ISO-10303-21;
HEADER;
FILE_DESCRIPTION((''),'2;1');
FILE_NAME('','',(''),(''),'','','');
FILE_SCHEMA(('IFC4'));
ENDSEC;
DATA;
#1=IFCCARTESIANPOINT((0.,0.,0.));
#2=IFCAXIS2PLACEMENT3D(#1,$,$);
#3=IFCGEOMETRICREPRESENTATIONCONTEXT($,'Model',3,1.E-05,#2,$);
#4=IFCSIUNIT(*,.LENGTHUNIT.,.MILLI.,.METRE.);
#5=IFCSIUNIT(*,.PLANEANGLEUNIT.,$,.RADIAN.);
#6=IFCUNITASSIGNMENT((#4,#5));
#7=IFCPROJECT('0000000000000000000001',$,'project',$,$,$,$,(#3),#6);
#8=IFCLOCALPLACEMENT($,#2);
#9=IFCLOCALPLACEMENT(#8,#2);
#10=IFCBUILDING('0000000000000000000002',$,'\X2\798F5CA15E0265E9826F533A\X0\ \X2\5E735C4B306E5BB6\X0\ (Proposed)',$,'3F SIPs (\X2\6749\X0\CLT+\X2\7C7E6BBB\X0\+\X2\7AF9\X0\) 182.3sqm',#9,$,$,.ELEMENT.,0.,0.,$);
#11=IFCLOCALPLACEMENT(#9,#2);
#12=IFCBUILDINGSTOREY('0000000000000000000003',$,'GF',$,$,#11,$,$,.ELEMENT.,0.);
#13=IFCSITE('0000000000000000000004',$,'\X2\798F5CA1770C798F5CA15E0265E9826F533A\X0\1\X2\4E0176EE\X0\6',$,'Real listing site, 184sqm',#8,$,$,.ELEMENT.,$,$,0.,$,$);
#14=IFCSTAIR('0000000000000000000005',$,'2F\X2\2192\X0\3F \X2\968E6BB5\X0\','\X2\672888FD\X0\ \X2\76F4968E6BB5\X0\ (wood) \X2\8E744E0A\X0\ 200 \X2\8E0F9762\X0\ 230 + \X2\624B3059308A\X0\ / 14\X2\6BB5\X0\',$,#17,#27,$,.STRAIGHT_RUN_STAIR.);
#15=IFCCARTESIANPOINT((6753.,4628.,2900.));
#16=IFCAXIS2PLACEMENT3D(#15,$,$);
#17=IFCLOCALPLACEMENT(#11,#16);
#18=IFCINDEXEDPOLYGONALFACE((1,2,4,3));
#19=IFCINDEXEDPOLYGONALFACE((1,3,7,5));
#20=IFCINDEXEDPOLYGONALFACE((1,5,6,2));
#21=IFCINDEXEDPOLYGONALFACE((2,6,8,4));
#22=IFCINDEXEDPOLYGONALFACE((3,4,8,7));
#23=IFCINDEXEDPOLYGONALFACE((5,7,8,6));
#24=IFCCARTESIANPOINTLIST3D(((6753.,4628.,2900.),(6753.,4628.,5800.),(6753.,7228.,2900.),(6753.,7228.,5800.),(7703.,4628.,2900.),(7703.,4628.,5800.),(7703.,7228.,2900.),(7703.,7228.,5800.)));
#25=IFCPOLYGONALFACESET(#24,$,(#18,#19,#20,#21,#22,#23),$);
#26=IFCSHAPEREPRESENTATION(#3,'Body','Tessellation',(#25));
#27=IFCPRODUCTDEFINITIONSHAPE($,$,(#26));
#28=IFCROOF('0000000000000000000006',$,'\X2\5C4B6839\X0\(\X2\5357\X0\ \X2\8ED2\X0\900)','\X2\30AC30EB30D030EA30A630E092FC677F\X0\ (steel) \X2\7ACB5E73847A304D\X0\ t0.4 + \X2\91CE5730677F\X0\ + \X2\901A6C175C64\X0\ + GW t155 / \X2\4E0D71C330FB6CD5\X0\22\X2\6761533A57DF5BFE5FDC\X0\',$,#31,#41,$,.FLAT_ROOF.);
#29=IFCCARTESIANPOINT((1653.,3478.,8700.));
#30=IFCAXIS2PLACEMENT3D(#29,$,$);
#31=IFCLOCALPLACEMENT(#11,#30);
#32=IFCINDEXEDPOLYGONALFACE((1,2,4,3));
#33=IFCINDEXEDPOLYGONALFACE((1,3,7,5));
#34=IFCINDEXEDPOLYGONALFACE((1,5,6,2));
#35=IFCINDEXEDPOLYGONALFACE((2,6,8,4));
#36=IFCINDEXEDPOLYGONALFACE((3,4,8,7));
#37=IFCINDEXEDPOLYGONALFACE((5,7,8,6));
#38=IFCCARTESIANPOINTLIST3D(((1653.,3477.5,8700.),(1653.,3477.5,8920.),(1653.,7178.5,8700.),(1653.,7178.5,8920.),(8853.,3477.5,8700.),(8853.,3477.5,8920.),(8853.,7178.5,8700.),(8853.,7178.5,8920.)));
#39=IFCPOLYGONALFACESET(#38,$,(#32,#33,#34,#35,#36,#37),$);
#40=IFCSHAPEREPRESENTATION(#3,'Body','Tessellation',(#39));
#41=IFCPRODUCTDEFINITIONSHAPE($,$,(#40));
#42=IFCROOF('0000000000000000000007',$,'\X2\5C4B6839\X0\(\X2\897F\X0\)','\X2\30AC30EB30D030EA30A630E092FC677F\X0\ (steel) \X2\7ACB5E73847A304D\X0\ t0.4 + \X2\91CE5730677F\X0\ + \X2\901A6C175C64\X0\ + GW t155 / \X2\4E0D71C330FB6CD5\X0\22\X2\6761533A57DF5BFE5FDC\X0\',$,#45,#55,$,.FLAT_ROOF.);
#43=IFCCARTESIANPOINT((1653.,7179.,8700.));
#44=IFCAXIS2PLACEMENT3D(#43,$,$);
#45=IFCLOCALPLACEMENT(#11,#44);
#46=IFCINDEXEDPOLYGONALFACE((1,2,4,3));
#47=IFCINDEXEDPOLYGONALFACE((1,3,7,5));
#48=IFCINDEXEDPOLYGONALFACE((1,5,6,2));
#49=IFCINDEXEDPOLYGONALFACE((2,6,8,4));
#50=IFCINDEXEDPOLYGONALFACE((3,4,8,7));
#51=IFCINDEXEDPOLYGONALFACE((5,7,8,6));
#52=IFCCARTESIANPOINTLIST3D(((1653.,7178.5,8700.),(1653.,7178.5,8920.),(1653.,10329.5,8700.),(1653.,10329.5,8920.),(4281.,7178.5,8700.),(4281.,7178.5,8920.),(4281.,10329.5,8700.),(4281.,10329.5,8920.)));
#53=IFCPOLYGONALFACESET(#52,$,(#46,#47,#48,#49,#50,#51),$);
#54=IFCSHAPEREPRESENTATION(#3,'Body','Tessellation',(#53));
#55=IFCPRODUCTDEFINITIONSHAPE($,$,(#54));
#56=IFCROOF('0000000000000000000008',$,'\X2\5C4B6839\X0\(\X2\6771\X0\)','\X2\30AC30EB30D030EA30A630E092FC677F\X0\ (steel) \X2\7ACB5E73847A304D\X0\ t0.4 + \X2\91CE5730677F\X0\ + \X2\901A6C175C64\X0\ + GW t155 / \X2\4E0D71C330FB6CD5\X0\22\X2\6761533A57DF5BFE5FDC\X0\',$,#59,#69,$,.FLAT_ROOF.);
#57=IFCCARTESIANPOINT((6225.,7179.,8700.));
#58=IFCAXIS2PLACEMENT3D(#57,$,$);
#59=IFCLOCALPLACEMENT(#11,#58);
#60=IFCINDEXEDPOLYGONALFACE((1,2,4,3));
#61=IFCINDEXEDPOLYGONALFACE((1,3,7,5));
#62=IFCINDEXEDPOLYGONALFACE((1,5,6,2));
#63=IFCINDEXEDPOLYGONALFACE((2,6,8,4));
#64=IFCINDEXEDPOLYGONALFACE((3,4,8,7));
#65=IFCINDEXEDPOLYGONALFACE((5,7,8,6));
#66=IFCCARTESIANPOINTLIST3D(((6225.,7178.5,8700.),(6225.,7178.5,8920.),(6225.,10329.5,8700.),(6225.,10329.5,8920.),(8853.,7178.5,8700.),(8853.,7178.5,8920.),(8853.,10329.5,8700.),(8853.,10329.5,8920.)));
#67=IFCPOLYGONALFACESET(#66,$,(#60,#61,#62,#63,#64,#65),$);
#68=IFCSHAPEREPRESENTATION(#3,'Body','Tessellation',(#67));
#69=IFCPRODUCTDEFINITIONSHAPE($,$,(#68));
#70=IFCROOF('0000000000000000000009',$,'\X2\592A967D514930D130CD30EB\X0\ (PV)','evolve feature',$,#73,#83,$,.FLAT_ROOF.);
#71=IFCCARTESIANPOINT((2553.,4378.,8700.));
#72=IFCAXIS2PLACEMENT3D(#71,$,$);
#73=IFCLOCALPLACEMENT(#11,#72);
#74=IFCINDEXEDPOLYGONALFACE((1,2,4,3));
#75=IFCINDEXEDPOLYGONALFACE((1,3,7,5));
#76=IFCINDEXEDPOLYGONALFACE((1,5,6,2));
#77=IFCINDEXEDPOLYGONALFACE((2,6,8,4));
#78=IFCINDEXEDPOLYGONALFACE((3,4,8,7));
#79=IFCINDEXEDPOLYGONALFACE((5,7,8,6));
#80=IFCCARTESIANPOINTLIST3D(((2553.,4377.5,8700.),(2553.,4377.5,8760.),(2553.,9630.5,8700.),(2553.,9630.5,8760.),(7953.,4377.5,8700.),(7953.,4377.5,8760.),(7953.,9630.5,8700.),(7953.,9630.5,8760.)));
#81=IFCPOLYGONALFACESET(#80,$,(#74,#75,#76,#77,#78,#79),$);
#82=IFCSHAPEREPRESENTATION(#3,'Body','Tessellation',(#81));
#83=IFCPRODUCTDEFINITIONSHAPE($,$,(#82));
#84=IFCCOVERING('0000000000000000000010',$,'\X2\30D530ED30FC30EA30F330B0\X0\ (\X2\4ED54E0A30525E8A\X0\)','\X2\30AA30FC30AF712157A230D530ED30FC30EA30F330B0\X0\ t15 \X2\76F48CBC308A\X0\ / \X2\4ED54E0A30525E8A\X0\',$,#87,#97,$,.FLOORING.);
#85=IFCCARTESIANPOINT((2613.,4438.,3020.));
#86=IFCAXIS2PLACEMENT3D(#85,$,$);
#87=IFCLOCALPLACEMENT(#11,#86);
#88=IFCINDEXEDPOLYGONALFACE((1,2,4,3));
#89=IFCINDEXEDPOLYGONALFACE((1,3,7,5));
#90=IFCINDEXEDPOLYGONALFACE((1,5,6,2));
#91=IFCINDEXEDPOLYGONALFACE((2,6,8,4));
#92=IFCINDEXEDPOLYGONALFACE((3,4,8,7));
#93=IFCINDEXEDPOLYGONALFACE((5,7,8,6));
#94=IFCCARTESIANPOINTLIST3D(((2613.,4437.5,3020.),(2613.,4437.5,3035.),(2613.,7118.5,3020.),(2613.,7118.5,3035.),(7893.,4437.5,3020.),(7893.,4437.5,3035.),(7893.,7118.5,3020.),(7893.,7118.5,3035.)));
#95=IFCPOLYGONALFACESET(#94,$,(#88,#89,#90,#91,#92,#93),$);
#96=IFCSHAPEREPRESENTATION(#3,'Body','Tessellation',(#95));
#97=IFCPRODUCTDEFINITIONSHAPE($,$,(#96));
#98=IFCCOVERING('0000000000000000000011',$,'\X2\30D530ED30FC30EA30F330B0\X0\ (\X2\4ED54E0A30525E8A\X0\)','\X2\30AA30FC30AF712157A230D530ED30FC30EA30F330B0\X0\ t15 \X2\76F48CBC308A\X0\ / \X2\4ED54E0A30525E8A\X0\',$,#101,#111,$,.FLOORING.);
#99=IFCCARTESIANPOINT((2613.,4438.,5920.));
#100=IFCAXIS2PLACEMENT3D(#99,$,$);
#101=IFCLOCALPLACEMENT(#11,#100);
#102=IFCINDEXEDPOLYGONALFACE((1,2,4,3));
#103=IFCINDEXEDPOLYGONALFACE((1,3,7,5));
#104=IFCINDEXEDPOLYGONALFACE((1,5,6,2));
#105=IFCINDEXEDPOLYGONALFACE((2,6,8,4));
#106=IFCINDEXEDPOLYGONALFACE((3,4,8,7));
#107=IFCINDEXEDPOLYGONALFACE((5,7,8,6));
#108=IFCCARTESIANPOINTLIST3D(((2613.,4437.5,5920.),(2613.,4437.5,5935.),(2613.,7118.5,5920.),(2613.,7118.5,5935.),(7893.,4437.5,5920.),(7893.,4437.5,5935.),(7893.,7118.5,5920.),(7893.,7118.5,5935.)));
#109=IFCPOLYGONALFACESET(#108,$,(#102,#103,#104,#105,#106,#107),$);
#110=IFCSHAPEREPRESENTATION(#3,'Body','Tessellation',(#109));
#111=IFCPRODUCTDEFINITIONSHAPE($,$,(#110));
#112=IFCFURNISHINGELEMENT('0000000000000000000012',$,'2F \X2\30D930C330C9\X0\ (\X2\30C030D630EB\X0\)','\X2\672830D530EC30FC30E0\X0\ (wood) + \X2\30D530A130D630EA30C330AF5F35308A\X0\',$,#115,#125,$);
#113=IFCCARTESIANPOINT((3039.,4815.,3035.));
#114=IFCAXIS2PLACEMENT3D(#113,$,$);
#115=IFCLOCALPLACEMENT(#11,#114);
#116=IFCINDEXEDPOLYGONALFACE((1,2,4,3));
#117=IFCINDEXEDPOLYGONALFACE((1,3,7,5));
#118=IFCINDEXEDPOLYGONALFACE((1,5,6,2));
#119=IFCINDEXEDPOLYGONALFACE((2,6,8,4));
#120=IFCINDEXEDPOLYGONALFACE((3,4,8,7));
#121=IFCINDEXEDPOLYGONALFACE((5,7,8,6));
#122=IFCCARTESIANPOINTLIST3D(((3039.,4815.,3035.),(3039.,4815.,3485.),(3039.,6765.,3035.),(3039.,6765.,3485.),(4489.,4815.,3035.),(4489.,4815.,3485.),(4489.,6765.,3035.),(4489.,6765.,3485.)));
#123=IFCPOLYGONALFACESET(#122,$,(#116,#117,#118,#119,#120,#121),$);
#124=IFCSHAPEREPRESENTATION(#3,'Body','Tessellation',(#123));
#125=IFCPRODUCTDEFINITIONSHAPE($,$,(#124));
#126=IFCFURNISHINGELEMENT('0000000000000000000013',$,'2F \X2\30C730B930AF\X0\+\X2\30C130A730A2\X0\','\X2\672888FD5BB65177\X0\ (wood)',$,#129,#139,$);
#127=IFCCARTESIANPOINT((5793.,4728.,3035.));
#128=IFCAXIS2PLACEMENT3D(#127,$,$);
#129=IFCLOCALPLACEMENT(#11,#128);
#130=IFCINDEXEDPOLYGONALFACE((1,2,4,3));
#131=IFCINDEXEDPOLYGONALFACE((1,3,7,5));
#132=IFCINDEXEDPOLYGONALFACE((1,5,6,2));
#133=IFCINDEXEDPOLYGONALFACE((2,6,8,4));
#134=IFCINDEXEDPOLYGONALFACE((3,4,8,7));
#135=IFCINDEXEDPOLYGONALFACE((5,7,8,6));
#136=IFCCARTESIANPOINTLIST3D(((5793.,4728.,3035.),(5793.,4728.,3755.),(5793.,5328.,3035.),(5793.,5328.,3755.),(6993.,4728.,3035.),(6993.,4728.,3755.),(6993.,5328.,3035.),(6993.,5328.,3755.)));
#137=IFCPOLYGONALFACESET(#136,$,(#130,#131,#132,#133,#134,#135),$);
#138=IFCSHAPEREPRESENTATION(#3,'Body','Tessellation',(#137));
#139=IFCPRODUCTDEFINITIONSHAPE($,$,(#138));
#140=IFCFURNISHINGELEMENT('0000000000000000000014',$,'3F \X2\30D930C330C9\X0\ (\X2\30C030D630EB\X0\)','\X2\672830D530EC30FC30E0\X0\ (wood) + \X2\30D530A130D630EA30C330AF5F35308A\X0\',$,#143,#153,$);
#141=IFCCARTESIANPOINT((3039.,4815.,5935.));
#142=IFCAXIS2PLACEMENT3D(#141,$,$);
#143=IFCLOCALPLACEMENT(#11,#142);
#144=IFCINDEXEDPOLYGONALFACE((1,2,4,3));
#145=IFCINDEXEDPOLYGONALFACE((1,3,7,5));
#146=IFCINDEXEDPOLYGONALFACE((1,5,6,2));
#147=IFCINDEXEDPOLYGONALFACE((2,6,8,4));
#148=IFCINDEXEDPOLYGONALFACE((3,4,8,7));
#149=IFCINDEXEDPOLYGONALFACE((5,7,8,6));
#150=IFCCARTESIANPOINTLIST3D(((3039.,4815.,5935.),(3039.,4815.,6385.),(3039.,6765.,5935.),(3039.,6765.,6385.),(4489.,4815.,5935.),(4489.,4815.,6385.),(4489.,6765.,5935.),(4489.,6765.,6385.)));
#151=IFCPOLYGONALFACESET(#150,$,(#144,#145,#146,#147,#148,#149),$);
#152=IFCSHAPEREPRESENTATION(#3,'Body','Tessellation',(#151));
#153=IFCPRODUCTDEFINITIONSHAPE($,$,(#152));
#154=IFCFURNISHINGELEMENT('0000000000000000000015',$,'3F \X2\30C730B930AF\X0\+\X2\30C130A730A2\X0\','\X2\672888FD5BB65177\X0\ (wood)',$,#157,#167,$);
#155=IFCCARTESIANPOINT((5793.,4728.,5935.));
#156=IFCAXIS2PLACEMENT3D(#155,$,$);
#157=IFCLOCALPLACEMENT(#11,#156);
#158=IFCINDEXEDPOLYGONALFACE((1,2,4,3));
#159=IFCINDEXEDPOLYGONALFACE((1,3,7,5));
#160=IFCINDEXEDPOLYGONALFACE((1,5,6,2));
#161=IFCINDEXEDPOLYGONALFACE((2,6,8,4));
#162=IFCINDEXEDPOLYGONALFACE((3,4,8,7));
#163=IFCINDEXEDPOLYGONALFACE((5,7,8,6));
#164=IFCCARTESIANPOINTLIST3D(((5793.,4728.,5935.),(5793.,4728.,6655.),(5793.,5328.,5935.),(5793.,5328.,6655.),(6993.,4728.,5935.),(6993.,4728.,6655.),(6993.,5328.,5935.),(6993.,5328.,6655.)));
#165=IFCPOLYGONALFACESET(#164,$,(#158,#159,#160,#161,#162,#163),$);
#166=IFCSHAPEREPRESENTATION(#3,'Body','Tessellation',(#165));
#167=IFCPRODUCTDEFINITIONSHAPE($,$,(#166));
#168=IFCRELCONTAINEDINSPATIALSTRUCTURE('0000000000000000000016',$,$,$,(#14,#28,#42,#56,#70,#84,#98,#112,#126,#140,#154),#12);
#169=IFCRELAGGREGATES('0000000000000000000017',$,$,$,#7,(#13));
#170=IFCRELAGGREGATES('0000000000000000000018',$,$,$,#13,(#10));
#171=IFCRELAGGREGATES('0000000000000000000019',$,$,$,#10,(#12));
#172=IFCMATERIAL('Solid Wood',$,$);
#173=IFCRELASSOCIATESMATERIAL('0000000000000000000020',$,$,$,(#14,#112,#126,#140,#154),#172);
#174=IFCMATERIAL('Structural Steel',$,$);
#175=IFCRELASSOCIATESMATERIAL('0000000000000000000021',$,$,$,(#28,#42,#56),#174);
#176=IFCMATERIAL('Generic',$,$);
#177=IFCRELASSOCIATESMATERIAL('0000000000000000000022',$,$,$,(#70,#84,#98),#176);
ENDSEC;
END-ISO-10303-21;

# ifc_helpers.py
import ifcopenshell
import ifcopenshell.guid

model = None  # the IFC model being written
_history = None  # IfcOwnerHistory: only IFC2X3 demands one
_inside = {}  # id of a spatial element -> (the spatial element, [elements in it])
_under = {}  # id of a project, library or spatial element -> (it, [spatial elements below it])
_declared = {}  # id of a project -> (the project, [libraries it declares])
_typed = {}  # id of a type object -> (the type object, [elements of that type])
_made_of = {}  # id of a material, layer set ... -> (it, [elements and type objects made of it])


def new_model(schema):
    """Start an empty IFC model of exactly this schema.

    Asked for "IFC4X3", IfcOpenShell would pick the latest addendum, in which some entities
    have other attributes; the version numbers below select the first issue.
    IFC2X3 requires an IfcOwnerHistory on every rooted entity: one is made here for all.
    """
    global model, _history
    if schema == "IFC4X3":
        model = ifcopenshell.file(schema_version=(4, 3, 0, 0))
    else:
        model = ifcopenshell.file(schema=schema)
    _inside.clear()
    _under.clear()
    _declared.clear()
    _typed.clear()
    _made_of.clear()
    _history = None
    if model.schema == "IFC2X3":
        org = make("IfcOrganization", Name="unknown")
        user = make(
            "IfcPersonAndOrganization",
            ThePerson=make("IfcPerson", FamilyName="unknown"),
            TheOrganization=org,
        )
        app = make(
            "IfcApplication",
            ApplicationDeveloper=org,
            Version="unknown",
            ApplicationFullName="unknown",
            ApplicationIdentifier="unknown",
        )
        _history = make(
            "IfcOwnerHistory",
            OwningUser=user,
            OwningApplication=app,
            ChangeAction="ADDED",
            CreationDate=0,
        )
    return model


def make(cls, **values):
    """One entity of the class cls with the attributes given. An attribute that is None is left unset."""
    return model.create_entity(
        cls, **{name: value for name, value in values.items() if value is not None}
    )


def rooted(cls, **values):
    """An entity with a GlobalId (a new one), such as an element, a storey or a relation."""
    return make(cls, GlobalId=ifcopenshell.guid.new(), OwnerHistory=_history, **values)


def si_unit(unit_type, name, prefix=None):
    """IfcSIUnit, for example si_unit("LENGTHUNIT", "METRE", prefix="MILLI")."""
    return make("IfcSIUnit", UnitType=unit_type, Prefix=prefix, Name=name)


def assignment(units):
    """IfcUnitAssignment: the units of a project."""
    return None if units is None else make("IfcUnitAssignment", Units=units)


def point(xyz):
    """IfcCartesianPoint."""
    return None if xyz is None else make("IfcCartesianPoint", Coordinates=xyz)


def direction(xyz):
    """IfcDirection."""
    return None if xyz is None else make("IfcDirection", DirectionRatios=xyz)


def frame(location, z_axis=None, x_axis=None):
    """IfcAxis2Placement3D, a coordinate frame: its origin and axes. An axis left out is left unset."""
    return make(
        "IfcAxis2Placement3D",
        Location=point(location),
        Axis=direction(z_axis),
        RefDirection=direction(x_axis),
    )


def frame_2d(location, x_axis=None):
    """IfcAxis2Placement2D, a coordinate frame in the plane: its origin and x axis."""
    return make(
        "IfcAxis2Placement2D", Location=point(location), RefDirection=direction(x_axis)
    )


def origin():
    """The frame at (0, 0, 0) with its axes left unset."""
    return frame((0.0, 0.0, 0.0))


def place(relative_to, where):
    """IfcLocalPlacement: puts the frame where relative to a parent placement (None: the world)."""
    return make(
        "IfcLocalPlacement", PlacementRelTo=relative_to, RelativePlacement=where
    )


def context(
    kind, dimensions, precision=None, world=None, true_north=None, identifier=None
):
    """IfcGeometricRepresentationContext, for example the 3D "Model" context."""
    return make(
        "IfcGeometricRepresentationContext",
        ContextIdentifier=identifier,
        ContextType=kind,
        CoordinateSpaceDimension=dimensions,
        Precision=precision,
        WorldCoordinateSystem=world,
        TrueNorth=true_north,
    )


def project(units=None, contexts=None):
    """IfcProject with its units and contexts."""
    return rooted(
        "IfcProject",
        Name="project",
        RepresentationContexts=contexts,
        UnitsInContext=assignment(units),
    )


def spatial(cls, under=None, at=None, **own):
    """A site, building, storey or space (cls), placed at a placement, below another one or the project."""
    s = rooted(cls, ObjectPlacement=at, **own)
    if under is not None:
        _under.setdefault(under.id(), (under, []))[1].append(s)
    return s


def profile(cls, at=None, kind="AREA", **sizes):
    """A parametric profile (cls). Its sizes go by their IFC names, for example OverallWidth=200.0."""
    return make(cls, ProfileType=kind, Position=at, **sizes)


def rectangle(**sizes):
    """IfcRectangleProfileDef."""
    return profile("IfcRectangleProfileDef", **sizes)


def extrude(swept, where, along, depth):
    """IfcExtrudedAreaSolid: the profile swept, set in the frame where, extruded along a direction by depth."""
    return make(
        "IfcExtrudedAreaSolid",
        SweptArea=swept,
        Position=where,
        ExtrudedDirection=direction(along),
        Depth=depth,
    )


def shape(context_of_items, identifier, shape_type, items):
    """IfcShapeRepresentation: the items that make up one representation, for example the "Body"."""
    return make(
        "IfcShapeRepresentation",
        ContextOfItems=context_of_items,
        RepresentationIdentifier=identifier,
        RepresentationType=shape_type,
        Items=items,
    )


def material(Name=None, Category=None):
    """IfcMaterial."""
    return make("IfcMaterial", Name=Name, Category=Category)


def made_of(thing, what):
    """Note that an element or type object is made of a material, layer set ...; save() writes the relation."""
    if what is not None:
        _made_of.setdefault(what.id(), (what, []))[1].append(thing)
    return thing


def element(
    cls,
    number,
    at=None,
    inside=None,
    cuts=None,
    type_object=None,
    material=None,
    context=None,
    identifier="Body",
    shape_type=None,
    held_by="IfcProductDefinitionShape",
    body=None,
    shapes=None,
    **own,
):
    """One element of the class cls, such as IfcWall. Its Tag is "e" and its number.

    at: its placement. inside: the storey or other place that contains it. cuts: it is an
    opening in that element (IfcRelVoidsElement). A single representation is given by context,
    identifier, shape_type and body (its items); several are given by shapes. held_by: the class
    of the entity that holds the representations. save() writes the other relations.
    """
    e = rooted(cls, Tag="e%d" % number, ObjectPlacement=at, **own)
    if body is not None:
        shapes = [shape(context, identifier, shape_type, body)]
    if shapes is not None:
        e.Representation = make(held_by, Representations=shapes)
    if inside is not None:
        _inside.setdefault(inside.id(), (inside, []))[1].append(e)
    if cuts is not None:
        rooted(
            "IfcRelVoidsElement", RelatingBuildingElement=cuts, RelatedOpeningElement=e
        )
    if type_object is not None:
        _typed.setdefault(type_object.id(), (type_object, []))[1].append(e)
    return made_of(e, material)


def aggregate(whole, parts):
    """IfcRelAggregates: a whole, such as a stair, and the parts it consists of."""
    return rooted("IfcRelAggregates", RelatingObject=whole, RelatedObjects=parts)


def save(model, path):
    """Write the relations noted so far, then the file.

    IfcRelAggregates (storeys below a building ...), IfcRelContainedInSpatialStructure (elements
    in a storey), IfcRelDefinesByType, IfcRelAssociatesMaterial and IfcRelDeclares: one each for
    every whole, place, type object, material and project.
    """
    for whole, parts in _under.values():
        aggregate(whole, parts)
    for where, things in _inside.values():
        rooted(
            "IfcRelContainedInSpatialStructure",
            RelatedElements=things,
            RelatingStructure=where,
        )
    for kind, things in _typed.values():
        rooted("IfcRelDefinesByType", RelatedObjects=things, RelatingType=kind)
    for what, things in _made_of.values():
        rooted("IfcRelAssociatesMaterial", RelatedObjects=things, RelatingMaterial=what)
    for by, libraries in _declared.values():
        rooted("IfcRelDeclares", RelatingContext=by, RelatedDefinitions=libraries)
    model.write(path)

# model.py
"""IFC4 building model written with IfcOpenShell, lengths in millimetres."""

from ifc_helpers import new_model, si_unit, frame, frame_2d, origin, place, context, project, spatial, rectangle, extrude, material, element, save


model = new_model("IFC4")

# Units and contexts
model_context = context("Model", 3, precision=1e-05, world=origin())
ifc_project = project(units=[si_unit("LENGTHUNIT", "METRE", prefix="MILLI"), si_unit("PLANEANGLEUNIT", "RADIAN")], contexts=[model_context])

# Site, building, storey
site_placement = place(None, origin())
site = spatial("IfcSite", under=ifc_project, at=site_placement, Name="福岡県福岡市早良区1丁目6", ObjectType="Real listing site, 184sqm", CompositionType="ELEMENT", RefElevation=0.0)
building_placement = place(site_placement, origin())
building = spatial("IfcBuilding", under=site, at=building_placement, Name="福岡市早良区 平屋の家 (Proposed)", ObjectType="3F SIPs (杉CLT+籾殻+竹) 182.3sqm", CompositionType="ELEMENT", ElevationOfRefHeight=0.0, ElevationOfTerrain=0.0)
storey_placement = place(building_placement, origin())
storey = spatial("IfcBuildingStorey", under=building, at=storey_placement, Name="GF", CompositionType="ELEMENT", Elevation=0.0)

# Shared definitions
ifc_material_1 = material(Name="Solid Wood")

# Stair
stair_placement = place(storey_placement, frame((6753.0, 4628.0, 2900.0)))
element("IfcStair", 1, at=stair_placement, inside=storey, material=ifc_material_1, Name="2F→3F 階段", Description="木製 直階段 (wood) 蹴上 200 踏面 230 + 手すり / 14段", PredefinedType="STRAIGHT_RUN_STAIR", context=model_context, shape_type="SweptSolid", body=[
    extrude(rectangle(XDim=950.0, YDim=2600.0, at=frame_2d((475.0, 1300.0))), frame((6753.0, 4628.0, 2900.0)), (0.0, 0.0, 1.0), 2900.0),
])

# Roofs
ifc_material_2 = material(Name="Structural Steel")
roof_1_placement = place(storey_placement, frame((1653.0, 3478.0, 8700.0)))
element("IfcRoof", 2, at=roof_1_placement, inside=storey, material=ifc_material_2, Name="屋根(南 軒900)", Description="ガルバリウム鋼板 (steel) 立平葺き t0.4 + 野地板 + 通気層 + GW t155 / 不燃・法22条区域対応", PredefinedType="FLAT_ROOF", context=model_context, shape_type="SweptSolid", body=[
    extrude(rectangle(XDim=7200.0, YDim=3701.0, at=frame_2d((3600.0, 1850.0))), frame((1653.0, 3478.0, 8700.0)), (0.0, 0.0, 1.0), 220.0),
])
roof_2_placement = place(storey_placement, frame((1653.0, 7179.0, 8700.0)))
element("IfcRoof", 3, at=roof_2_placement, inside=storey, material=ifc_material_2, Name="屋根(西)", Description="ガルバリウム鋼板 (steel) 立平葺き t0.4 + 野地板 + 通気層 + GW t155 / 不燃・法22条区域対応", PredefinedType="FLAT_ROOF", context=model_context, shape_type="SweptSolid", body=[
    extrude(rectangle(XDim=2628.0, YDim=3151.0, at=frame_2d((1314.0, 1575.0))), frame((1653.0, 7179.0, 8700.0)), (0.0, 0.0, 1.0), 220.0),
])
roof_3_placement = place(storey_placement, frame((6225.0, 7179.0, 8700.0)))
element("IfcRoof", 4, at=roof_3_placement, inside=storey, material=ifc_material_2, Name="屋根(東)", Description="ガルバリウム鋼板 (steel) 立平葺き t0.4 + 野地板 + 通気層 + GW t155 / 不燃・法22条区域対応", PredefinedType="FLAT_ROOF", context=model_context, shape_type="SweptSolid", body=[
    extrude(rectangle(XDim=2628.0, YDim=3151.0, at=frame_2d((1314.0, 1575.0))), frame((6225.0, 7179.0, 8700.0)), (0.0, 0.0, 1.0), 220.0),
])
ifc_material_3 = material(Name="Generic")
roof_4_placement = place(storey_placement, frame((2553.0, 4378.0, 8700.0)))
element("IfcRoof", 5, at=roof_4_placement, inside=storey, material=ifc_material_3, Name="太陽光パネル (PV)", Description="evolve feature", PredefinedType="FLAT_ROOF", context=model_context, shape_type="SweptSolid", body=[
    extrude(rectangle(XDim=5400.0, YDim=5253.0, at=frame_2d((2700.0, 2626.0))), frame((2553.0, 4378.0, 8700.0)), (0.0, 0.0, 1.0), 60.0),
])

# Coverings
covering_1_placement = place(storey_placement, frame((2613.0, 4438.0, 3020.0)))
element("IfcCovering", 6, at=covering_1_placement, inside=storey, material=ifc_material_3, Name="フローリング (仕上げ床)", Description="オーク無垢フローリング t15 直貼り / 仕上げ床", PredefinedType="FLOORING", context=model_context, shape_type="SweptSolid", body=[
    extrude(rectangle(XDim=5280.0, YDim=2681.0, at=frame_2d((2640.0, 1340.0))), frame((2613.0, 4438.0, 3020.0)), (0.0, 0.0, 1.0), 15.0),
])
covering_2_placement = place(storey_placement, frame((2613.0, 4438.0, 5920.0)))
element("IfcCovering", 7, at=covering_2_placement, inside=storey, material=ifc_material_3, Name="フローリング (仕上げ床)", Description="オーク無垢フローリング t15 直貼り / 仕上げ床", PredefinedType="FLOORING", context=model_context, shape_type="SweptSolid", body=[
    extrude(rectangle(XDim=5280.0, YDim=2681.0, at=frame_2d((2640.0, 1340.0))), frame((2613.0, 4438.0, 5920.0)), (0.0, 0.0, 1.0), 15.0),
])

# Furnishing elements
furnishing_1_placement = place(storey_placement, frame((3039.0, 4815.0, 3035.0)))
element("IfcFurnishingElement", 8, at=furnishing_1_placement, inside=storey, material=ifc_material_1, Name="2F ベッド (ダブル)", Description="木フレーム (wood) + ファブリック張り", context=model_context, shape_type="SweptSolid", body=[
    extrude(rectangle(XDim=1450.0, YDim=1950.0, at=frame_2d((725.0, 975.0))), frame((3039.0, 4815.0, 3035.0)), (0.0, 0.0, 1.0), 450.0),
])
furnishing_2_placement = place(storey_placement, frame((5793.0, 4728.0, 3035.0)))
element("IfcFurnishingElement", 9, at=furnishing_2_placement, inside=storey, material=ifc_material_1, Name="2F デスク+チェア", Description="木製家具 (wood)", context=model_context, shape_type="SweptSolid", body=[
    extrude(rectangle(XDim=1200.0, YDim=600.0, at=frame_2d((600.0, 300.0))), frame((5793.0, 4728.0, 3035.0)), (0.0, 0.0, 1.0), 720.0),
])
furnishing_3_placement = place(storey_placement, frame((3039.0, 4815.0, 5935.0)))
element("IfcFurnishingElement", 10, at=furnishing_3_placement, inside=storey, material=ifc_material_1, Name="3F ベッド (ダブル)", Description="木フレーム (wood) + ファブリック張り", context=model_context, shape_type="SweptSolid", body=[
    extrude(rectangle(XDim=1450.0, YDim=1950.0, at=frame_2d((725.0, 975.0))), frame((3039.0, 4815.0, 5935.0)), (0.0, 0.0, 1.0), 450.0),
])
furnishing_4_placement = place(storey_placement, frame((5793.0, 4728.0, 5935.0)))
element("IfcFurnishingElement", 11, at=furnishing_4_placement, inside=storey, material=ifc_material_1, Name="3F デスク+チェア", Description="木製家具 (wood)", context=model_context, shape_type="SweptSolid", body=[
    extrude(rectangle(XDim=1200.0, YDim=600.0, at=frame_2d((600.0, 300.0))), frame((5793.0, 4728.0, 5935.0)), (0.0, 0.0, 1.0), 720.0),
])

save(model, "model.ifc")
